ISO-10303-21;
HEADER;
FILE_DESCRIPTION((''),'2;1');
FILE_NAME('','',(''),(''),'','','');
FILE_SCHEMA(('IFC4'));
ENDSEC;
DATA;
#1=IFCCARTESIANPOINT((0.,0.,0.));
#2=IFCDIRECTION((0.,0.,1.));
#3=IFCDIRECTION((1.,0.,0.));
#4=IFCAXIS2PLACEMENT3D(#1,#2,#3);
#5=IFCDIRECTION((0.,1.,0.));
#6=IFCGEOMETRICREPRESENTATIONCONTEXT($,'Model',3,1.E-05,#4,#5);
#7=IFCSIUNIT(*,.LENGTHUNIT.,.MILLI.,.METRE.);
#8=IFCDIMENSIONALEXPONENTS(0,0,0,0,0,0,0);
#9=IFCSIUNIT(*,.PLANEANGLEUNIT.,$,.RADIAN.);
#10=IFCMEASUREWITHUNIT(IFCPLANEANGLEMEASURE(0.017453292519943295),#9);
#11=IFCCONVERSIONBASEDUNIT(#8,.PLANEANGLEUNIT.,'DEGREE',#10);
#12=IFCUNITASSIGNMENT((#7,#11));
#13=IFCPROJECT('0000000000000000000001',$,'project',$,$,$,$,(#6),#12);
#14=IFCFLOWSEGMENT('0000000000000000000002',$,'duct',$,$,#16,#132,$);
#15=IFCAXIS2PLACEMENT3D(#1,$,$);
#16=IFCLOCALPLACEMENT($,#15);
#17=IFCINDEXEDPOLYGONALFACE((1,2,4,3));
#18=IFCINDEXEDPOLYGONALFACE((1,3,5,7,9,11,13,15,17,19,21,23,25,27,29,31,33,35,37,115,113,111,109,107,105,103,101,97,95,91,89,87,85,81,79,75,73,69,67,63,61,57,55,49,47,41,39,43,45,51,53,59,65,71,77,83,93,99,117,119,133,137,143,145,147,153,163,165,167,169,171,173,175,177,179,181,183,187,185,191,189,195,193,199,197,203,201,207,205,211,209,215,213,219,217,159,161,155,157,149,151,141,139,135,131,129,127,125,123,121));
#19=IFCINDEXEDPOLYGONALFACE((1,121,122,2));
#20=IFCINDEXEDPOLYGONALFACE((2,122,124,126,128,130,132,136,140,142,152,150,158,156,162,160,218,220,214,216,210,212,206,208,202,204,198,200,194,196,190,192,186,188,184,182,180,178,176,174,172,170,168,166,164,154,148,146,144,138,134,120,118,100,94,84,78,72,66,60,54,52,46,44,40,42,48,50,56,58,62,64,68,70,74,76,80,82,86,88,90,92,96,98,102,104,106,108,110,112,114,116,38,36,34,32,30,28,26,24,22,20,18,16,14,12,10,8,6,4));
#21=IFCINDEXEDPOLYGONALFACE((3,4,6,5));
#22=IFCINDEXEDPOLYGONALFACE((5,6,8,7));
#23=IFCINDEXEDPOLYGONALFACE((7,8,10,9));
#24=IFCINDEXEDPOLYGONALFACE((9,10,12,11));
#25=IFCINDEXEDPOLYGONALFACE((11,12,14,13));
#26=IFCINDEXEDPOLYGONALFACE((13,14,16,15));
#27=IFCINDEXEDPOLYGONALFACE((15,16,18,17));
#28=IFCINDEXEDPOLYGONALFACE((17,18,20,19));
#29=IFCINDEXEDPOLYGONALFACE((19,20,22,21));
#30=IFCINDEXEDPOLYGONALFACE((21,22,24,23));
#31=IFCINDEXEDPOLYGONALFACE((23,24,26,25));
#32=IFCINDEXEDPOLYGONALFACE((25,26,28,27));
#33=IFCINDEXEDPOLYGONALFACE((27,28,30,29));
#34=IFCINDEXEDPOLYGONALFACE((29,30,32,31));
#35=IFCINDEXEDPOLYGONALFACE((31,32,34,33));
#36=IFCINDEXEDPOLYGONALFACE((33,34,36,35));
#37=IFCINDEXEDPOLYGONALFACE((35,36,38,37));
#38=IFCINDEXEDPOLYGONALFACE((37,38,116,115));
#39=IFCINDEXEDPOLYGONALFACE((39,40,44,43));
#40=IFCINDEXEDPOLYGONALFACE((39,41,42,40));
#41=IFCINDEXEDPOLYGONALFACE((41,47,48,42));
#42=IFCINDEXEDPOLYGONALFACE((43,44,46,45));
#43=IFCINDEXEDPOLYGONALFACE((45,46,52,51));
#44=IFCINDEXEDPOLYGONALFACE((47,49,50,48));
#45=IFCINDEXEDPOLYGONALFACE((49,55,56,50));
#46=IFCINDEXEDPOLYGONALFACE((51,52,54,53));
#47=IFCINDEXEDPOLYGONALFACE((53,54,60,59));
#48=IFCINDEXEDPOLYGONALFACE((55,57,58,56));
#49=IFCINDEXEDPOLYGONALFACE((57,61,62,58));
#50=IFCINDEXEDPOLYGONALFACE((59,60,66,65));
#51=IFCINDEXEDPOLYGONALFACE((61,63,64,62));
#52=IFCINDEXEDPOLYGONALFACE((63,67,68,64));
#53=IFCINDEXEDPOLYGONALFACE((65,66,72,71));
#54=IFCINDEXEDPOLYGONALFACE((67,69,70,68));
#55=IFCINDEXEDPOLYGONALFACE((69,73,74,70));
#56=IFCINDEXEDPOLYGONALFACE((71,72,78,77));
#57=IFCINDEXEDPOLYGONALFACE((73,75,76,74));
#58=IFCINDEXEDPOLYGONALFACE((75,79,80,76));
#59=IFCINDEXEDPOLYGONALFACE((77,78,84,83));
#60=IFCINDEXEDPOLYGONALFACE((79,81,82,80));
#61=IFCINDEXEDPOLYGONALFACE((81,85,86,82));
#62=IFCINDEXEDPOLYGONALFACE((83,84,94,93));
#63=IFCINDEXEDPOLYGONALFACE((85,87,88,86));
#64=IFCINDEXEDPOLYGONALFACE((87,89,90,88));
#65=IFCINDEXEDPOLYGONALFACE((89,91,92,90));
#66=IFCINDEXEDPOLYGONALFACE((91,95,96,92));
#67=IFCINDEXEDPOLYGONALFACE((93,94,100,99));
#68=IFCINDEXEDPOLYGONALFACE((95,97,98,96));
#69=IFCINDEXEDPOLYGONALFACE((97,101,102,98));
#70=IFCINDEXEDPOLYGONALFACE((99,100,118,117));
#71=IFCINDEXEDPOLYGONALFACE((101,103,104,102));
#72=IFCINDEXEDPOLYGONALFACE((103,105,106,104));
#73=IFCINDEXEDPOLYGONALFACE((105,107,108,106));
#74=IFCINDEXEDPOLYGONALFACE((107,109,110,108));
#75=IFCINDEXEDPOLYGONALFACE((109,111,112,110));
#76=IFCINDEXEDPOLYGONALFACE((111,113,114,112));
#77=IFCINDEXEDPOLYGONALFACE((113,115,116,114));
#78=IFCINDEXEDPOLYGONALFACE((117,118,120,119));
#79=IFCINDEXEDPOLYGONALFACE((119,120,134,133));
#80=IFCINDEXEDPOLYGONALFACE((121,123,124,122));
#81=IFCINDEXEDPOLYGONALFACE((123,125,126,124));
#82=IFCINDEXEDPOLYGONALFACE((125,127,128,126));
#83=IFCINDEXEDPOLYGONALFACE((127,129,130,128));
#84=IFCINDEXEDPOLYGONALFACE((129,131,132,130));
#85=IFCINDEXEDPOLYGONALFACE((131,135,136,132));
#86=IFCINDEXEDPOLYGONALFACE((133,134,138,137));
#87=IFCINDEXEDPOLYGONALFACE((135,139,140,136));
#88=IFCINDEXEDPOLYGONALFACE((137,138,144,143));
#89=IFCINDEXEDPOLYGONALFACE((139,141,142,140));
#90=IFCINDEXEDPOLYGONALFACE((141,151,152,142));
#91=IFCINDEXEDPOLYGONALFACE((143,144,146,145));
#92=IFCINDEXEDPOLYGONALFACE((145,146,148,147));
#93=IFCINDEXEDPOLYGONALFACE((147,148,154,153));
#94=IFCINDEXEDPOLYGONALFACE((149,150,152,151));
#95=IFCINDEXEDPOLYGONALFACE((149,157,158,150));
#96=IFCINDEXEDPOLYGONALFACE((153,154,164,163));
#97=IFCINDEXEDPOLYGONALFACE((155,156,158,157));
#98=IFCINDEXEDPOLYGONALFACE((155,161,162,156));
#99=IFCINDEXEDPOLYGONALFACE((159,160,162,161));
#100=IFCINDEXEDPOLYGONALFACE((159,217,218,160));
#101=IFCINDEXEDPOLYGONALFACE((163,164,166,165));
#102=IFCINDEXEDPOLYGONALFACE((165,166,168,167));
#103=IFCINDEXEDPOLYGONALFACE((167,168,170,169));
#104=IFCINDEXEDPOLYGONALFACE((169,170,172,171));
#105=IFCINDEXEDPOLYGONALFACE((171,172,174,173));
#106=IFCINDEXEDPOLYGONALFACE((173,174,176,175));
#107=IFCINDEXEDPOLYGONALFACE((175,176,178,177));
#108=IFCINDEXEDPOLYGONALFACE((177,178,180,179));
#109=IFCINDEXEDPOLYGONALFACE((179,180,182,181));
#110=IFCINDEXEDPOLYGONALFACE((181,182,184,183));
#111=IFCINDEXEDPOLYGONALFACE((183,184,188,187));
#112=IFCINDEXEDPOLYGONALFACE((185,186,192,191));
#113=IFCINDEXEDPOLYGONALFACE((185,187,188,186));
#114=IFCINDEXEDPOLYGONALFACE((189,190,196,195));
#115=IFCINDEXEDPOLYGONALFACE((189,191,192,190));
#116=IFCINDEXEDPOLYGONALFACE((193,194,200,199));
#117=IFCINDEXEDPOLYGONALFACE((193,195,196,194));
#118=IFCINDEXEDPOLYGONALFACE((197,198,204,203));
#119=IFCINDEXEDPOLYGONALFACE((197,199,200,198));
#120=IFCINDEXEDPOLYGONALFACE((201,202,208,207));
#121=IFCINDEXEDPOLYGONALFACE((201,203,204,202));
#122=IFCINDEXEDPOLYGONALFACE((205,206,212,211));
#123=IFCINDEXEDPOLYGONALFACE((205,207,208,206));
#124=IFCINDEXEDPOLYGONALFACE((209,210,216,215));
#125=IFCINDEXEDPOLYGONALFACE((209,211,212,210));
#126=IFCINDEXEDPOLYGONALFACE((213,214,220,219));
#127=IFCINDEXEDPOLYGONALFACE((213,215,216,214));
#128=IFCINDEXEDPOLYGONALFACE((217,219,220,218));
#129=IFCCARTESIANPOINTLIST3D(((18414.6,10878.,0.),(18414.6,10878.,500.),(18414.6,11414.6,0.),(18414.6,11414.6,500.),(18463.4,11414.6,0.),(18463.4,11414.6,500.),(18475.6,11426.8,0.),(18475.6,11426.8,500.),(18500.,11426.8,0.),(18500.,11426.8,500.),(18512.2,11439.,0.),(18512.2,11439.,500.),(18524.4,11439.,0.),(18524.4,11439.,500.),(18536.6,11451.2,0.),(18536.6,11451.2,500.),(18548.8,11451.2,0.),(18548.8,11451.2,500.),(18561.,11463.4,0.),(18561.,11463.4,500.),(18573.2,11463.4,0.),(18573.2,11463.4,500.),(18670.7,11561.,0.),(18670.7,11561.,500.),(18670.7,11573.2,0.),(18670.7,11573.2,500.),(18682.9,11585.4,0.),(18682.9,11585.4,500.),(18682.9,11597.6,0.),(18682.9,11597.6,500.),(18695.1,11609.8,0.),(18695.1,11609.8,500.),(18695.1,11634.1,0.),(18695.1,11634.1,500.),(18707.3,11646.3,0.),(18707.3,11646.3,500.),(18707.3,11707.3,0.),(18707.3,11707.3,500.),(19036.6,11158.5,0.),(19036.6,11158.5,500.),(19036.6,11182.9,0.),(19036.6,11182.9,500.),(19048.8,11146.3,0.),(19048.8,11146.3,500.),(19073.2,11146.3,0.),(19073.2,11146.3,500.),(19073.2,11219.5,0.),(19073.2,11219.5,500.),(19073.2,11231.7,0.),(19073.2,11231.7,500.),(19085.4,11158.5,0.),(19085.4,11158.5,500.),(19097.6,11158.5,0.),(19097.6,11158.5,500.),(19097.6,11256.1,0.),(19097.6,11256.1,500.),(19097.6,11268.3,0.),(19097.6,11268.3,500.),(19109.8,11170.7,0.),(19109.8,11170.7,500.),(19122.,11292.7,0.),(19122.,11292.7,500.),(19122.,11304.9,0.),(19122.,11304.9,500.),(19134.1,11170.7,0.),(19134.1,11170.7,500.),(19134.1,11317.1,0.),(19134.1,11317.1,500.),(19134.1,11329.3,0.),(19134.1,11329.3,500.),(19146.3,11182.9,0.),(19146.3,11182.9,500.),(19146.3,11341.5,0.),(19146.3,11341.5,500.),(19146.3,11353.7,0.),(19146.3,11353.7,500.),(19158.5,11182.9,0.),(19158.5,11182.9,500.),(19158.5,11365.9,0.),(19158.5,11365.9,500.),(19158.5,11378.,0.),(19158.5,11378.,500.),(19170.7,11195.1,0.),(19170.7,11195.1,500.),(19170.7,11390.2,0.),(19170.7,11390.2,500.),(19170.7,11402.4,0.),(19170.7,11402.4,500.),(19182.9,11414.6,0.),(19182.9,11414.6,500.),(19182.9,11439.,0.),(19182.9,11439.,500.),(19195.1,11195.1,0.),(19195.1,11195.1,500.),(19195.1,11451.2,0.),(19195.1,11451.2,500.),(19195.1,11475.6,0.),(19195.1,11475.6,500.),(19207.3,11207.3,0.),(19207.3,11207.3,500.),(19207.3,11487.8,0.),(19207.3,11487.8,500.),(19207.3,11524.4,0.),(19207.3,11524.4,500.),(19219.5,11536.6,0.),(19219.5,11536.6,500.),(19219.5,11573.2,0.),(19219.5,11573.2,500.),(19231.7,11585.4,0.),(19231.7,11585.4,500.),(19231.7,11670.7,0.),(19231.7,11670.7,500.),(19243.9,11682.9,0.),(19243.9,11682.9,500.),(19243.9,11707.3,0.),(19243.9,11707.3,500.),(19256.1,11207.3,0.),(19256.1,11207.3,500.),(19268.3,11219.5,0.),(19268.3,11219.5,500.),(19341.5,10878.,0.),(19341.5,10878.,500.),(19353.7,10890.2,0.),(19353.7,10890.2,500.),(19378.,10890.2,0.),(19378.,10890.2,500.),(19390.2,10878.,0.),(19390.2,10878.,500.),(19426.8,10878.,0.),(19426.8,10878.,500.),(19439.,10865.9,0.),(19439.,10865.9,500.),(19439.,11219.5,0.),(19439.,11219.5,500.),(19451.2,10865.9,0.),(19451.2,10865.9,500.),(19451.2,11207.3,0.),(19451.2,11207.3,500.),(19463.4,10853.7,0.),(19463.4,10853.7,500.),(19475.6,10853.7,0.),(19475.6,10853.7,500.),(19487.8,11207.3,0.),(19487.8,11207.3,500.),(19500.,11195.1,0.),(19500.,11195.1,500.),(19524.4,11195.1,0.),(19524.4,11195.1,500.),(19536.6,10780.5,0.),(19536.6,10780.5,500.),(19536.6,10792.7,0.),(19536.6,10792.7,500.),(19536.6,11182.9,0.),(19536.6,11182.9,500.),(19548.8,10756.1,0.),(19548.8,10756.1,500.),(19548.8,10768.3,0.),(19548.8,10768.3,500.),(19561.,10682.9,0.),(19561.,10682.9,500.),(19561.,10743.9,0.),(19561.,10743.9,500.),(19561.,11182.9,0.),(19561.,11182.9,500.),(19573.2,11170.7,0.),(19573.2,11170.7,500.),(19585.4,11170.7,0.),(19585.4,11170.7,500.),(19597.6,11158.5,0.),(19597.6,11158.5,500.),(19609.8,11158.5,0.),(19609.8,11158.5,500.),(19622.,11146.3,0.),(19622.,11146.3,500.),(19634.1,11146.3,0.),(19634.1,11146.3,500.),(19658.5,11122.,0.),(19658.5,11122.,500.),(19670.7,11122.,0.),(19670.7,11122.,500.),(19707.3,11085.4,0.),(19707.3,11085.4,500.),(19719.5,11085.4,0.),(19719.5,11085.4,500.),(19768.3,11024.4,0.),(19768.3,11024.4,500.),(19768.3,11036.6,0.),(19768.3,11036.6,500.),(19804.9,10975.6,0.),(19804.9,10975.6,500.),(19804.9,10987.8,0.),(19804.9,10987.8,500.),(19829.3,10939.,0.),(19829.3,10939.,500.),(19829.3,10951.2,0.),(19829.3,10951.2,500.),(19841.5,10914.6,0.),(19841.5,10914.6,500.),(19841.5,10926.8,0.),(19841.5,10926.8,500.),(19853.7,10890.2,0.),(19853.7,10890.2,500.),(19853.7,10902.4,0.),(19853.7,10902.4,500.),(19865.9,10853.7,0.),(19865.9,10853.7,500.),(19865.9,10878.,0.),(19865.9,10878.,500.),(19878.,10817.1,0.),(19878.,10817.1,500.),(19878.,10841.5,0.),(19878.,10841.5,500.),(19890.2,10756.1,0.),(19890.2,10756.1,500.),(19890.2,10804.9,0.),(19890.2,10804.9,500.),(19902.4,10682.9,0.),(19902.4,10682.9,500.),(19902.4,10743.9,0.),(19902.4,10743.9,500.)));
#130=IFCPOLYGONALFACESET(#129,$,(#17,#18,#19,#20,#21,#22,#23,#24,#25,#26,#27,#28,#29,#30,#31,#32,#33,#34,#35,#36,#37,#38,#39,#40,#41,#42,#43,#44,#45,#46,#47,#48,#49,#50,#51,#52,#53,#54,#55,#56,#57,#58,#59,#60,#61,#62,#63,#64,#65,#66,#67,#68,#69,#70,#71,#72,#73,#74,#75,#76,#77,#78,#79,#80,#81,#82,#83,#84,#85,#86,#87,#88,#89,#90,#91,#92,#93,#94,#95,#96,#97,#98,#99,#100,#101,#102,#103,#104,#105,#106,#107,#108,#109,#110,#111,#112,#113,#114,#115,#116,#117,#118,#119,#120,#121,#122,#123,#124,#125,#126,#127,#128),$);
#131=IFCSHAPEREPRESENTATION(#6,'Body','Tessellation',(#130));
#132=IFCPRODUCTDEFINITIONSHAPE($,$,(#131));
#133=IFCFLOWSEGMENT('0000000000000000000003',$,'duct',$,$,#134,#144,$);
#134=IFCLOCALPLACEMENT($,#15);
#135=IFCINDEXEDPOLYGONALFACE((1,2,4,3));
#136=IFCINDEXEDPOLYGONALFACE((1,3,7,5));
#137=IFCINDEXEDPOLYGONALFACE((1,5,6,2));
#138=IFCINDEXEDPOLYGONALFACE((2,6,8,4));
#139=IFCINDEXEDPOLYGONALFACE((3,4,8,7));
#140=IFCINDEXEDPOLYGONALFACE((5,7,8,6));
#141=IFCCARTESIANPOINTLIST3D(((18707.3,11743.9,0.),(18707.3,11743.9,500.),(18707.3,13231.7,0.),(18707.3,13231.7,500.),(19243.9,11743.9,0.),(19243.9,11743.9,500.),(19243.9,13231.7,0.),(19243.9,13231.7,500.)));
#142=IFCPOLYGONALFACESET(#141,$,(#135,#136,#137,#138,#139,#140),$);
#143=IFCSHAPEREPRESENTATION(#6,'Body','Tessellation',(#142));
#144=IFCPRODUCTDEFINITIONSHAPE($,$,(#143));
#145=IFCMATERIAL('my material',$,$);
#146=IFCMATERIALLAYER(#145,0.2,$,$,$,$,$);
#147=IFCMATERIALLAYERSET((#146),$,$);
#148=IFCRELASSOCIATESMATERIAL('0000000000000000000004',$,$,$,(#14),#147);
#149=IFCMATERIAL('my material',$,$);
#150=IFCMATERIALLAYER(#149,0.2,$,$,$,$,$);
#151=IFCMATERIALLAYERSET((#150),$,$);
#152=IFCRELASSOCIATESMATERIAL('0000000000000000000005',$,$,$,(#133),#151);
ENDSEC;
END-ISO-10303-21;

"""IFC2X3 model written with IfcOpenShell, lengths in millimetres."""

from ifc_helpers import new_model, entity, si_unit, converted_unit, direction, origin_with_axes, place, context, project, polyline, outline, extrude, material, layer, layer_set, layer_usage, element, save


model = new_model("IFC2X3")

# Units and contexts
model_context = context("Model", 3, precision=1e-05, world=origin_with_axes(), true_north=direction((0.0, 1.0, 0.0)))
ifc_project = project(units=[si_unit("LENGTHUNIT", "METRE", prefix="MILLI"), converted_unit("PLANEANGLEUNIT", "DEGREE", entity("IfcPlaneAngleMeasure", 0.017453292519943295), si_unit("PLANEANGLEUNIT", "RADIAN"), dimensions=[0, 0, 0, 0, 0, 0, 0])], contexts=[model_context])

# Flow segments
ifc_material_1 = material(Name="my material")
ifc_layer_1 = layer(ifc_material_1, 0.2)
ifc_layer_set_1 = layer_set([ifc_layer_1])
ifc_layer_usage_1 = layer_usage(ifc_layer_set_1, "AXIS2", "POSITIVE", -0.1)
flow_segment_1_placement = place(None, origin_with_axes())
element("IfcFlowSegment", 1, at=flow_segment_1_placement, material=ifc_layer_usage_1, Name="duct", context=model_context, shape_type="SweptSolid", body=[
    extrude(outline(polyline([(18414.6, 10878.0), (19341.5, 10878.0), (19353.7, 10890.2), (19378.0, 10890.2), (19390.2, 10878.0), (19426.8, 10878.0), (19439.0, 10865.9), (19451.2, 10865.9), (19463.4, 10853.7), (19475.6, 10853.7), (19536.6, 10792.7), (19536.6, 10780.5), (19548.8, 10768.3), (19548.8, 10756.1), (19561.0, 10743.9), (19561.0, 10682.9), (19902.4, 10682.9), (19902.4, 10743.9), (19890.2, 10756.1), (19890.2, 10804.9), (19878.0, 10817.1), (19878.0, 10841.5), (19865.9, 10853.7), (19865.9, 10878.0), (19853.7, 10890.2), (19853.7, 10902.4), (19841.5, 10914.6), (19841.5, 10926.8), (19829.3, 10939.0), (19829.3, 10951.2), (19804.9, 10975.6), (19804.9, 10987.8), (19768.3, 11024.4), (19768.3, 11036.6), (19719.5, 11085.4), (19707.3, 11085.4), (19670.7, 11122.0), (19658.5, 11122.0), (19634.1, 11146.3), (19622.0, 11146.3), (19609.8, 11158.5), (19597.6, 11158.5), (19585.4, 11170.7), (19573.2, 11170.7), (19561.0, 11182.9), (19536.6, 11182.9), (19524.4, 11195.1), (19500.0, 11195.1), (19487.8, 11207.3), (19451.2, 11207.3), (19439.0, 11219.5), (19268.3, 11219.5), (19256.1, 11207.3), (19207.3, 11207.3), (19195.1, 11195.1), (19170.7, 11195.1), (19158.5, 11182.9), (19146.3, 11182.9), (19134.1, 11170.7), (19109.8, 11170.7), (19097.6, 11158.5), (19085.4, 11158.5), (19073.2, 11146.3), (19048.8, 11146.3), (19036.6, 11158.5), (19036.6, 11182.9), (19073.2, 11219.5), (19073.2, 11231.7), (19097.6, 11256.1), (19097.6, 11268.3), (19122.0, 11292.7), (19122.0, 11304.9), (19134.1, 11317.1), (19134.1, 11329.3), (19146.3, 11341.5), (19146.3, 11353.7), (19158.5, 11365.9), (19158.5, 11378.0), (19170.7, 11390.2), (19170.7, 11402.4), (19182.9, 11414.6), (19182.9, 11439.0), (19195.1, 11451.2), (19195.1, 11475.6), (19207.3, 11487.8), (19207.3, 11524.4), (19219.5, 11536.6), (19219.5, 11573.2), (19231.7, 11585.4), (19231.7, 11670.7), (19243.9, 11682.9), (19243.9, 11707.3), (18707.3, 11707.3), (18707.3, 11646.3), (18695.1, 11634.1), (18695.1, 11609.8), (18682.9, 11597.6), (18682.9, 11585.4), (18670.7, 11573.2), (18670.7, 11561.0), (18573.2, 11463.4), (18561.0, 11463.4), (18548.8, 11451.2), (18536.6, 11451.2), (18524.4, 11439.0), (18512.2, 11439.0), (18500.0, 11426.8), (18475.6, 11426.8), (18463.4, 11414.6), (18414.6, 11414.6), (18414.6, 10878.0)])), origin_with_axes(), (0.0, 0.0, 1.0), 500.0),
])
ifc_material_2 = material(Name="my material")
ifc_layer_2 = layer(ifc_material_2, 0.2)
ifc_layer_set_2 = layer_set([ifc_layer_2])
ifc_layer_usage_2 = layer_usage(ifc_layer_set_2, "AXIS2", "POSITIVE", -0.1)
flow_segment_2_placement = place(None, origin_with_axes())
element("IfcFlowSegment", 2, at=flow_segment_2_placement, material=ifc_layer_usage_2, Name="duct", context=model_context, shape_type="SweptSolid", body=[
    extrude(outline(polyline([(18707.3, 11743.9), (19243.9, 11743.9), (19243.9, 13231.7), (18707.3, 13231.7), (18707.3, 11743.9)])), origin_with_axes(), (0.0, 0.0, 1.0), 500.0),
])

save(model, "model.ifc")
